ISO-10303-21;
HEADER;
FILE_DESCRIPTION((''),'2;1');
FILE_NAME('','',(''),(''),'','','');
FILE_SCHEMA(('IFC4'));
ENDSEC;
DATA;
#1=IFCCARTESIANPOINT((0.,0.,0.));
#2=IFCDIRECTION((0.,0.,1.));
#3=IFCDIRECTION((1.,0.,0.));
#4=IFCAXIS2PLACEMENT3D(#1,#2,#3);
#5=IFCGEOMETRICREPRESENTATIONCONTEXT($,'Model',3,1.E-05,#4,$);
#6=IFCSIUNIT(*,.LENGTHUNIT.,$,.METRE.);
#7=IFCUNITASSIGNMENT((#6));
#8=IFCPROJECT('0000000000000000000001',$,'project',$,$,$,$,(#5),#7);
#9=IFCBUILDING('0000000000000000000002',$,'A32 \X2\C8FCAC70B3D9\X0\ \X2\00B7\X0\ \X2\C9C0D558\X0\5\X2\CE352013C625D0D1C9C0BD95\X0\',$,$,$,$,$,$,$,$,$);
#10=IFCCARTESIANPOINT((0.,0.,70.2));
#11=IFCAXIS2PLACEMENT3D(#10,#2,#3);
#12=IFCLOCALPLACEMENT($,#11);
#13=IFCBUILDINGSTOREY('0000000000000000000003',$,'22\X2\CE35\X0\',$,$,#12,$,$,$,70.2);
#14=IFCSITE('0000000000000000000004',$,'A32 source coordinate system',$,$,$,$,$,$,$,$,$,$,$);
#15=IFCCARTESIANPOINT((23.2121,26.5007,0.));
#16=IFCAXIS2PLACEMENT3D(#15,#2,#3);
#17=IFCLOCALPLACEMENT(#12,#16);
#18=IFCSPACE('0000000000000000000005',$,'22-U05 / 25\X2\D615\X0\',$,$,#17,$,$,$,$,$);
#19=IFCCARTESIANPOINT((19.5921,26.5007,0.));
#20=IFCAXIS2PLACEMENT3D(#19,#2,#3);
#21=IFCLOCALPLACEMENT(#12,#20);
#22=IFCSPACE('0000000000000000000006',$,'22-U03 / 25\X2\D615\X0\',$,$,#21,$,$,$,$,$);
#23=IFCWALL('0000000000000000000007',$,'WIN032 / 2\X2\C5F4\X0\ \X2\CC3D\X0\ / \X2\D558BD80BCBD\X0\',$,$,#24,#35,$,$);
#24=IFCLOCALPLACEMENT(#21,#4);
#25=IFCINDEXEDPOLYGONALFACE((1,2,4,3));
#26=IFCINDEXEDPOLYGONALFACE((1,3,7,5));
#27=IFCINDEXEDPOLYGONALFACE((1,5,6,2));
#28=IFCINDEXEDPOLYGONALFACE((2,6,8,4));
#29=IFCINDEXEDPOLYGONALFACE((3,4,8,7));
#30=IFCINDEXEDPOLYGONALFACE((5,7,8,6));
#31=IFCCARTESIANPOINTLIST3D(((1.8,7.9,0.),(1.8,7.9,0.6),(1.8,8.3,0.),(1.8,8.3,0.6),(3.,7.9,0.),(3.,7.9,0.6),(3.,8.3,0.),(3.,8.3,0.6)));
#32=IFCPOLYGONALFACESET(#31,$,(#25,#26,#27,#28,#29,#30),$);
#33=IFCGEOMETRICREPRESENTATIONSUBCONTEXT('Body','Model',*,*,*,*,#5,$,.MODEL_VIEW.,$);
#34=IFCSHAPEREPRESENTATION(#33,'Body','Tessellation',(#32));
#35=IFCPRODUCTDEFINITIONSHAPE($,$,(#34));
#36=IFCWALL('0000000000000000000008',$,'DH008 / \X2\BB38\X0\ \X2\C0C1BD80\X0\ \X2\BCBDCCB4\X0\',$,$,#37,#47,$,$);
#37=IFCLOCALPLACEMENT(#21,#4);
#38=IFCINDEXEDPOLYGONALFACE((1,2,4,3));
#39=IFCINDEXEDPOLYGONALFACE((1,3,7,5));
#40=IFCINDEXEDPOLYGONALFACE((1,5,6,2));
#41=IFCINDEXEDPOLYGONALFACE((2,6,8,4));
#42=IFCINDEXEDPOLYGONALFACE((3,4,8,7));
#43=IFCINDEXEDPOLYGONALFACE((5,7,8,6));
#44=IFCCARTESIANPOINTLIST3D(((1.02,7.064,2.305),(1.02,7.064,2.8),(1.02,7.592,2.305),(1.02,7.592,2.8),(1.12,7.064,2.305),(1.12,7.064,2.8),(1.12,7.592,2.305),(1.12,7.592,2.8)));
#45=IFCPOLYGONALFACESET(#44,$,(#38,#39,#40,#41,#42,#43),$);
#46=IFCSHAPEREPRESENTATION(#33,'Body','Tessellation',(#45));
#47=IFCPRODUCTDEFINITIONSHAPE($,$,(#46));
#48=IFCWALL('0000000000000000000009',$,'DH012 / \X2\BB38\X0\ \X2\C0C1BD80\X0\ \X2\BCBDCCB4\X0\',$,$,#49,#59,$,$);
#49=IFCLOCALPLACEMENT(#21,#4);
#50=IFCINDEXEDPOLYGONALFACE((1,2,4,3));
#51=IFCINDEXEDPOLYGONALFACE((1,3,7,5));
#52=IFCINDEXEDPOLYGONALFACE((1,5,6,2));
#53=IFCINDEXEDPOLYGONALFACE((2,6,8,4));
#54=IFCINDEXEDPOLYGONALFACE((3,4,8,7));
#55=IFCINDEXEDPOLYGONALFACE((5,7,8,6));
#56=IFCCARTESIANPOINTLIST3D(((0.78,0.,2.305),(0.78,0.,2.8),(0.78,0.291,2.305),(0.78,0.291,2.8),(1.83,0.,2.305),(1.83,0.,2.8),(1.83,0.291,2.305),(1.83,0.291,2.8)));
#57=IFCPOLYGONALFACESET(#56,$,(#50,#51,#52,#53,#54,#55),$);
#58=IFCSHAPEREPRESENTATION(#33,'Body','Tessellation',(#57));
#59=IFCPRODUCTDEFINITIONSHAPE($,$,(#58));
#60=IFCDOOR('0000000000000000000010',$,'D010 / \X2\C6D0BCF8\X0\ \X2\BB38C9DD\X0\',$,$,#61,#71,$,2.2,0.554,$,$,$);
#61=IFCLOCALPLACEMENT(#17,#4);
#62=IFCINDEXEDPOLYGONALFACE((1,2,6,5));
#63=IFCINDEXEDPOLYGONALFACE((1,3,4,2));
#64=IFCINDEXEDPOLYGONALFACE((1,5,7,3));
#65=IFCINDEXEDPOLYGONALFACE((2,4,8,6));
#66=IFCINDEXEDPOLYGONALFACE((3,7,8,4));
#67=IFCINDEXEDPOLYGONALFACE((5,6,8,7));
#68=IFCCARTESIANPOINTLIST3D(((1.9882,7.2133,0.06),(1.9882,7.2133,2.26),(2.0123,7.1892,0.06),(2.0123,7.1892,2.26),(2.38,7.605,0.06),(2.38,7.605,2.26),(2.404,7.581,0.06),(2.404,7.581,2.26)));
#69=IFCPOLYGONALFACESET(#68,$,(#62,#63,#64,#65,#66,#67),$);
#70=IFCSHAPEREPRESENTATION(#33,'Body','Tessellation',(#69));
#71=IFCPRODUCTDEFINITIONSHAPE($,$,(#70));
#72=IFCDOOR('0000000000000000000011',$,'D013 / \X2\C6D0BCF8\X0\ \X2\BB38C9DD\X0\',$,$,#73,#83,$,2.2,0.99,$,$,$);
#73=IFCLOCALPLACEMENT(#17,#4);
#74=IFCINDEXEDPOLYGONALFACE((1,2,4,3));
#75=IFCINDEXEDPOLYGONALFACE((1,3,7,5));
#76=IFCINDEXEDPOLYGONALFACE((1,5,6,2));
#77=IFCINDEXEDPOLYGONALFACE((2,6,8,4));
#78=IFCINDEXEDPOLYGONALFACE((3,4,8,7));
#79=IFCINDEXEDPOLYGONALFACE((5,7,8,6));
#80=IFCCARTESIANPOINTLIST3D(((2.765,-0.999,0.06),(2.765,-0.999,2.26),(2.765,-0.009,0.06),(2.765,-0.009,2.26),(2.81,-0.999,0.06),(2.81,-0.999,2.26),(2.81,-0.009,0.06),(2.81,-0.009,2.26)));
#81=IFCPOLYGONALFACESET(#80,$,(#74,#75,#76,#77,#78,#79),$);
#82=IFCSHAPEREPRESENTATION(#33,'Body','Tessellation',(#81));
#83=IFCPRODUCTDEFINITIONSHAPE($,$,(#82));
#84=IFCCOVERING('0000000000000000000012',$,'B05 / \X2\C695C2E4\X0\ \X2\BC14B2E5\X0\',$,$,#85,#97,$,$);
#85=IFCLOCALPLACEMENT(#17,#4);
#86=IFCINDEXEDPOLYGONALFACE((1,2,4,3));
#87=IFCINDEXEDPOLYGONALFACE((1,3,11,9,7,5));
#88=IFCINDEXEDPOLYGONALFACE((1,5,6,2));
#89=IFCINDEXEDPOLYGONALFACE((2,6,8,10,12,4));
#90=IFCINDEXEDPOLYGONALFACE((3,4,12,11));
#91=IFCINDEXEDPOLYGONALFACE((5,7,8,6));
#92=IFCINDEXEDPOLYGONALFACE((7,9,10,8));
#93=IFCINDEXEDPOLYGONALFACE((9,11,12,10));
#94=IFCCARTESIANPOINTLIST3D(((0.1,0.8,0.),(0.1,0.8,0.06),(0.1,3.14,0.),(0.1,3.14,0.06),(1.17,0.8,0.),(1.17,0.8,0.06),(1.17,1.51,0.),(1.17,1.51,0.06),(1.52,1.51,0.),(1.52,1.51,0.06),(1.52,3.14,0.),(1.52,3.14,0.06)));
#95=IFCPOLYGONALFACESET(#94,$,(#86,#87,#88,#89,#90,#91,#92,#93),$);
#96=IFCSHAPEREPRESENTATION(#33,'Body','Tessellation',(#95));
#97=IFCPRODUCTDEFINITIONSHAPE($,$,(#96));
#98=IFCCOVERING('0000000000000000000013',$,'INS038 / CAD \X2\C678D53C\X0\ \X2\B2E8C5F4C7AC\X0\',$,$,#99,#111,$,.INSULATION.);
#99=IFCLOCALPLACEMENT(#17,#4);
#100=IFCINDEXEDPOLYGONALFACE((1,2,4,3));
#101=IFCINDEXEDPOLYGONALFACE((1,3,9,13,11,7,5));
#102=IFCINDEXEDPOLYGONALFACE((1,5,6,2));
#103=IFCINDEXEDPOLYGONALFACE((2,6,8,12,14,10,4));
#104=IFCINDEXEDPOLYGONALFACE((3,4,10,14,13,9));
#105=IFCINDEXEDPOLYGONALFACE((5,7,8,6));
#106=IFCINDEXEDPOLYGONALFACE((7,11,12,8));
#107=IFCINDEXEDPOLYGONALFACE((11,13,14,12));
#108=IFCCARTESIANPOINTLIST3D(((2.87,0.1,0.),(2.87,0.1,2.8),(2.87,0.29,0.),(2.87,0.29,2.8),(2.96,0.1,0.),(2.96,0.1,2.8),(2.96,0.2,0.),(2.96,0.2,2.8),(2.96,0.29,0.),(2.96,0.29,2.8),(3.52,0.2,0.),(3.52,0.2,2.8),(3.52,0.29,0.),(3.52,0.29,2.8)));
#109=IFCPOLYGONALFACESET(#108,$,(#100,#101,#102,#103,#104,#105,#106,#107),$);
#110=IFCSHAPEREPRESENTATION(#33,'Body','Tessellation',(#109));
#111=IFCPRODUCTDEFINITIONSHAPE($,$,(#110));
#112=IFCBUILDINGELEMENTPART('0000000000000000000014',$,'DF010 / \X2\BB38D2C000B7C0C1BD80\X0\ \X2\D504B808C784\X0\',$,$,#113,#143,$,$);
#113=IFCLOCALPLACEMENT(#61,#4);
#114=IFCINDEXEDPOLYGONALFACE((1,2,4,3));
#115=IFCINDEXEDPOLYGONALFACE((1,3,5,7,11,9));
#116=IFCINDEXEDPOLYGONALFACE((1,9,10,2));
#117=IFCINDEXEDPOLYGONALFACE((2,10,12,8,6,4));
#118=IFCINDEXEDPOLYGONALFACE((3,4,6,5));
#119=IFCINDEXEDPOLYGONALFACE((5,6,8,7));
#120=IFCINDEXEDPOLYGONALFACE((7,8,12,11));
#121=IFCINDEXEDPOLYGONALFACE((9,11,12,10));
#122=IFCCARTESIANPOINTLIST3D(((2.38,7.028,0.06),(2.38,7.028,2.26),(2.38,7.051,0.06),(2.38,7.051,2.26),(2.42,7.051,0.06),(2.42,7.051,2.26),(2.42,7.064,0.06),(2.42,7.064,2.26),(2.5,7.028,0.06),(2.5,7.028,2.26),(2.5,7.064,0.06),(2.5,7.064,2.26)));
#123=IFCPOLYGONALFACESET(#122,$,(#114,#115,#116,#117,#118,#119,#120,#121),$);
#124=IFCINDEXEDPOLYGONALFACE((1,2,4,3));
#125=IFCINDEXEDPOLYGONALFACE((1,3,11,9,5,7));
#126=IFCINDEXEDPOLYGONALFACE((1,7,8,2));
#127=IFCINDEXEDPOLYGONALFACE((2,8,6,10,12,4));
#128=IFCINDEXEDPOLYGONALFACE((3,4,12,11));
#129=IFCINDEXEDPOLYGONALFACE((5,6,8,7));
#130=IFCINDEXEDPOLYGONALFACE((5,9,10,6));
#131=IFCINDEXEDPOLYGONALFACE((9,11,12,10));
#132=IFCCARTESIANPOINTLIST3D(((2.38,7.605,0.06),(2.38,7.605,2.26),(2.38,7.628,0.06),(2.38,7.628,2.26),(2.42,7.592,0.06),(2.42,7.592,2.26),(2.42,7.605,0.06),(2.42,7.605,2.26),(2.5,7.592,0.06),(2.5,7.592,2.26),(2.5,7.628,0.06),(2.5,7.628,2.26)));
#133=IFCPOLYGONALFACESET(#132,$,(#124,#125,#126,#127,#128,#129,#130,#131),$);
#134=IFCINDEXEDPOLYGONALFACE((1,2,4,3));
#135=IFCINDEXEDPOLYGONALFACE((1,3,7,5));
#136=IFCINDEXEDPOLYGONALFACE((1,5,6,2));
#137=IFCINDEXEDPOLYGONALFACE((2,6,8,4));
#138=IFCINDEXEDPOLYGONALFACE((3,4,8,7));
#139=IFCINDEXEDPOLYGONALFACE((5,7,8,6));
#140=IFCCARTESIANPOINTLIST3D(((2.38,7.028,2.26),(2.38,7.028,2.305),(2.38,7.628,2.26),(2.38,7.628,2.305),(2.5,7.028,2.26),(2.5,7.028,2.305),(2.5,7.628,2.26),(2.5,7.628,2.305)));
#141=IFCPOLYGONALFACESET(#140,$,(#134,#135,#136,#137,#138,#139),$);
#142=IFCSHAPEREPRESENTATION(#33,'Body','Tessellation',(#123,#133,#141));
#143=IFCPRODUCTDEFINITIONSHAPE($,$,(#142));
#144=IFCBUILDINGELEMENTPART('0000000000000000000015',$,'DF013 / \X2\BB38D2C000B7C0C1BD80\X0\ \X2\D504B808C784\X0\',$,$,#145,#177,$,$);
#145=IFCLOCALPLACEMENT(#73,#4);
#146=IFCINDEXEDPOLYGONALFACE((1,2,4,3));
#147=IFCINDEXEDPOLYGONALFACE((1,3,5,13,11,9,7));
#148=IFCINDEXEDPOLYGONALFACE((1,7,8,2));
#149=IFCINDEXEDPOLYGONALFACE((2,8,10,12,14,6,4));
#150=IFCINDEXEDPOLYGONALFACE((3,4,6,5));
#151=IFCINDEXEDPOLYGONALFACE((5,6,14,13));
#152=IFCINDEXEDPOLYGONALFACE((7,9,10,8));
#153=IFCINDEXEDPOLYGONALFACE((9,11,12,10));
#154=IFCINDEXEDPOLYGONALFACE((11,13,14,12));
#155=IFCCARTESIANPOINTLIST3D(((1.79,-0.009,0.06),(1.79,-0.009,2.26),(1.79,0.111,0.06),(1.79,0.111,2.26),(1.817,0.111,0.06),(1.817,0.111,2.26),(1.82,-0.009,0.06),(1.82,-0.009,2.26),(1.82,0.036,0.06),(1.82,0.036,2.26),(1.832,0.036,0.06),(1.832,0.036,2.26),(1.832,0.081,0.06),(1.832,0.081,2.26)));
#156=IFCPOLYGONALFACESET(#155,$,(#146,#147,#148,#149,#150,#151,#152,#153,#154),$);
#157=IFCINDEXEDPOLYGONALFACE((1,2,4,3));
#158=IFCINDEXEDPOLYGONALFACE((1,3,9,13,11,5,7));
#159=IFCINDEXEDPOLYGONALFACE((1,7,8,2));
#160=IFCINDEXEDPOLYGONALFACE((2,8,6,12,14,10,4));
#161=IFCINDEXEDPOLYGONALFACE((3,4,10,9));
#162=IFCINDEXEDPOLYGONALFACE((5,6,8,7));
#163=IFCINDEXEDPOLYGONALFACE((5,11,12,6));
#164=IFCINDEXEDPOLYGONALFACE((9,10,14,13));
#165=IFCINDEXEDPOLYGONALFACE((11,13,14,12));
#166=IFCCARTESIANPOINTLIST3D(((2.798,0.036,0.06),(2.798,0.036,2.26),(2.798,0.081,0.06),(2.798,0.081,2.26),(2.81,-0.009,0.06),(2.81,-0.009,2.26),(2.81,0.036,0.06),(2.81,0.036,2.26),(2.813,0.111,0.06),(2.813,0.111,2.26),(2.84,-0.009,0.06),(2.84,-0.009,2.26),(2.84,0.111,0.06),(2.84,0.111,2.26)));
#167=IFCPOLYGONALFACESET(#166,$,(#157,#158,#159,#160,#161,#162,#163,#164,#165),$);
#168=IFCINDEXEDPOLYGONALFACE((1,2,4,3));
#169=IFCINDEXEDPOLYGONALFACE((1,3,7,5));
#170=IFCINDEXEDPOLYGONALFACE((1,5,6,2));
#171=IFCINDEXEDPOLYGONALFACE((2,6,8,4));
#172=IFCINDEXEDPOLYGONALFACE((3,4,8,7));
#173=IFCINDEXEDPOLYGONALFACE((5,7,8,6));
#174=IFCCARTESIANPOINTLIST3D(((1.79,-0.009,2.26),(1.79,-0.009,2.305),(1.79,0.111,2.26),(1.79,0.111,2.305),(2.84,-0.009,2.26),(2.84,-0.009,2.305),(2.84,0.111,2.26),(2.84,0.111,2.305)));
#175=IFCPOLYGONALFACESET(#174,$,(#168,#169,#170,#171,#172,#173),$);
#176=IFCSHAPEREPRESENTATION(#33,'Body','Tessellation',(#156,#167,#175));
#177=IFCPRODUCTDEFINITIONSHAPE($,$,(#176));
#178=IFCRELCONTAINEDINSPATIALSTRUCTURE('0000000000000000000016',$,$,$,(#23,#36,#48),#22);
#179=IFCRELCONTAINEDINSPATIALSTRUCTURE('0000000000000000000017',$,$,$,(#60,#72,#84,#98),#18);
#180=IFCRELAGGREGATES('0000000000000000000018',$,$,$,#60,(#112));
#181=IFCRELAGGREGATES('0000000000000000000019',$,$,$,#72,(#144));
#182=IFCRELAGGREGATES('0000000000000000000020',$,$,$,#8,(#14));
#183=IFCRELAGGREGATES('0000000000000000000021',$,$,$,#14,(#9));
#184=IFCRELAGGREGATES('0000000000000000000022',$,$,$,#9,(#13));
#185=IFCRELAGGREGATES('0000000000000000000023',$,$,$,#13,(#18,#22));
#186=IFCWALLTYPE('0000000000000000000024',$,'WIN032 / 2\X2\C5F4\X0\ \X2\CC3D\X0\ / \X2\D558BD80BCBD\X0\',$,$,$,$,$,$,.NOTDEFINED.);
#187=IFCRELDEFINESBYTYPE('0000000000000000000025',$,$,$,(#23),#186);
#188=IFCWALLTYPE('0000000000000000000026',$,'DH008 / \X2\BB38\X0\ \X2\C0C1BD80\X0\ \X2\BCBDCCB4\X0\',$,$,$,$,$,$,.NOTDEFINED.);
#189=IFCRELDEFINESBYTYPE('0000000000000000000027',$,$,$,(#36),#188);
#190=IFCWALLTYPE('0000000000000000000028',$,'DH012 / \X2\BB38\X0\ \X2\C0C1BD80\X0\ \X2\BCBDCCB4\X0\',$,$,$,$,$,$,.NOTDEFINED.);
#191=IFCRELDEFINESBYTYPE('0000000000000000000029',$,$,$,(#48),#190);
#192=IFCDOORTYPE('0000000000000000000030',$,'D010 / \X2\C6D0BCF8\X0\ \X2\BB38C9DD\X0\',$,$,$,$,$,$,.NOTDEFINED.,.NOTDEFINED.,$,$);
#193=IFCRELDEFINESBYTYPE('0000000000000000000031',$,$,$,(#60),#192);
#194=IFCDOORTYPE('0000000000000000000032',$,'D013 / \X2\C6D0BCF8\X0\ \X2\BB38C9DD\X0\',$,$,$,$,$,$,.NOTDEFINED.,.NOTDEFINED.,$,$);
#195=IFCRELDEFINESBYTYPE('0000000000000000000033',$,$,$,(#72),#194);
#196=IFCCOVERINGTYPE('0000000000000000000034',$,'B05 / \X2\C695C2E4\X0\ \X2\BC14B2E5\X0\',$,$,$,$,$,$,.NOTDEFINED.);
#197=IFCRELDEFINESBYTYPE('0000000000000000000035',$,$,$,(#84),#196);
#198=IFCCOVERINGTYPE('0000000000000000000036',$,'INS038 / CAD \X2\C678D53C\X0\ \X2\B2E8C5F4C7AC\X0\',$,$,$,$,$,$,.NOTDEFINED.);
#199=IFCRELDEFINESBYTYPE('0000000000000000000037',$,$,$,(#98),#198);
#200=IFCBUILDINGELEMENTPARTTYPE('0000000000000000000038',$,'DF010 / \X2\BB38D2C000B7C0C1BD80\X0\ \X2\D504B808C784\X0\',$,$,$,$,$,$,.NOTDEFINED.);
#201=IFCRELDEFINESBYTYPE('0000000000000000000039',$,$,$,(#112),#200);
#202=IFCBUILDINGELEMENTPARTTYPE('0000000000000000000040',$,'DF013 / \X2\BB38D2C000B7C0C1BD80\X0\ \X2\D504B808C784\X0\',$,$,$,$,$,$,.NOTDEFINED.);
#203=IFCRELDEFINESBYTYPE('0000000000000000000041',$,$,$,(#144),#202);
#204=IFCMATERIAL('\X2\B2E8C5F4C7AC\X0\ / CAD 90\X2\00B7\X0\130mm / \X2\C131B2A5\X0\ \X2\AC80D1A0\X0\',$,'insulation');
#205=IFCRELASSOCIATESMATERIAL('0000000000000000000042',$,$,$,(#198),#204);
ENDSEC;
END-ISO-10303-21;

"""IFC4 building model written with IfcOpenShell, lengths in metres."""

from ifc_helpers import new_model, si_unit, frame, origin, origin_with_axes, place, context, subcontext, project, spatial, polyline, outline, extrude, source, transform, mapped, material, type_object, type_shapes, element, aggregate, save


model = new_model("IFC4")

# Units and contexts
model_context = context("Model", 3, precision=1e-05, world=origin_with_axes())
body_context = subcontext(model_context, "Body", "Model", "MODEL_VIEW")
ifc_project = project(units=[si_unit("LENGTHUNIT", "METRE")], contexts=[model_context])

# Site, building, storey, space
storey_placement = place(None, frame((0.0, 0.0, 70.2), z_axis=(0.0, 0.0, 1.0), x_axis=(1.0, 0.0, 0.0)))
space_1_placement = place(storey_placement, frame((23.2121, 26.5007, 0.0), z_axis=(0.0, 0.0, 1.0), x_axis=(1.0, 0.0, 0.0)))
site = spatial("IfcSite", under=ifc_project, Name="A32 source coordinate system")
building = spatial("IfcBuilding", under=site, Name="A32 주거동 · 지하5층–옥탑지붕")
storey = spatial("IfcBuildingStorey", under=building, at=storey_placement, Name="22층", Elevation=70.2)
space_1 = spatial("IfcSpace", under=storey, at=space_1_placement, Name="22-U05 / 25형")

# Shared definitions
space_2_placement = place(storey_placement, frame((19.5921, 26.5007, 0.0), z_axis=(0.0, 0.0, 1.0), x_axis=(1.0, 0.0, 0.0)))
space_2 = spatial("IfcSpace", under=storey, at=space_2_placement, Name="22-U03 / 25형")

# Walls
wall_type_1 = type_object("IfcWallType", Name="WIN032 / 2열 창 / 하부벽", PredefinedType="NOTDEFINED")
shared_shape_1 = source(origin(), body_context, "Body", "SweptSolid", [
    extrude(outline(polyline([(3.0, 7.9), (1.8, 7.9), (1.8, 8.3), (3.0, 8.3), (3.0, 7.9)])), origin(), (0.0, 0.0, 1.0), 0.6),
])
type_shapes(wall_type_1, [shared_shape_1])
wall_1_placement = place(space_2_placement, origin_with_axes())
element("IfcWall", 1, at=wall_1_placement, inside=space_2, type_object=wall_type_1, Name="WIN032 / 2열 창 / 하부벽", context=body_context, shape_type="MappedRepresentation", body=[
    mapped(shared_shape_1, transform((0.0, 0.0, 0.0), scale=1.0)),
])
wall_type_2 = type_object("IfcWallType", Name="DH008 / 문 상부 벽체", PredefinedType="NOTDEFINED")
shared_shape_2 = source(origin(), body_context, "Body", "SweptSolid", [
    extrude(outline(polyline([(1.12, 7.064), (1.02, 7.064), (1.02, 7.592), (1.12, 7.592), (1.12, 7.064)])), frame((0.0, 0.0, 2.305)), (0.0, 0.0, 1.0), 0.495),
])
type_shapes(wall_type_2, [shared_shape_2])
wall_2_placement = place(space_2_placement, origin_with_axes())
element("IfcWall", 2, at=wall_2_placement, inside=space_2, type_object=wall_type_2, Name="DH008 / 문 상부 벽체", context=body_context, shape_type="MappedRepresentation", body=[
    mapped(shared_shape_2, transform((0.0, 0.0, 0.0), scale=1.0)),
])
wall_type_3 = type_object("IfcWallType", Name="DH012 / 문 상부 벽체", PredefinedType="NOTDEFINED")
shared_shape_3 = source(origin(), body_context, "Body", "SweptSolid", [
    extrude(outline(polyline([(0.78, 0.0), (0.78, 0.291), (1.83, 0.291), (1.83, 0.0), (0.78, 0.0)])), frame((0.0, 0.0, 2.305)), (0.0, 0.0, 1.0), 0.495),
])
type_shapes(wall_type_3, [shared_shape_3])
wall_3_placement = place(space_2_placement, origin_with_axes())
element("IfcWall", 3, at=wall_3_placement, inside=space_2, type_object=wall_type_3, Name="DH012 / 문 상부 벽체", context=body_context, shape_type="MappedRepresentation", body=[
    mapped(shared_shape_3, transform((0.0, 0.0, 0.0), scale=1.0)),
])

# Doors
door_type_1 = type_object("IfcDoorType", Name="D010 / 원본 문짝", OperationType="NOTDEFINED", PredefinedType="NOTDEFINED")
shared_shape_4 = source(origin(), body_context, "Body", "SweptSolid", [
    extrude(outline(polyline([(2.0123, 7.1892), (1.9882, 7.2133), (2.38, 7.605), (2.404, 7.581), (2.0123, 7.1892)])), frame((0.0, 0.0, 0.06)), (0.0, 0.0, 1.0), 2.2),
])
type_shapes(door_type_1, [shared_shape_4])
door_1_placement = place(space_1_placement, origin_with_axes())
door_1 = element("IfcDoor", 4, at=door_1_placement, inside=space_1, type_object=door_type_1, Name="D010 / 원본 문짝", OverallHeight=2.2, OverallWidth=0.554, context=body_context, shape_type="MappedRepresentation", body=[
    mapped(shared_shape_4, transform((0.0, 0.0, 0.0), scale=1.0)),
])
door_type_2 = type_object("IfcDoorType", Name="D013 / 원본 문짝", OperationType="NOTDEFINED", PredefinedType="NOTDEFINED")
shared_shape_5 = source(origin(), body_context, "Body", "SweptSolid", [
    extrude(outline(polyline([(2.81, -0.009), (2.81, -0.999), (2.765, -0.999), (2.765, -0.009), (2.81, -0.009)])), frame((0.0, 0.0, 0.06)), (0.0, 0.0, 1.0), 2.2),
])
type_shapes(door_type_2, [shared_shape_5])
door_2_placement = place(space_1_placement, origin_with_axes())
door_2 = element("IfcDoor", 5, at=door_2_placement, inside=space_1, type_object=door_type_2, Name="D013 / 원본 문짝", OverallHeight=2.2, OverallWidth=0.99, context=body_context, shape_type="MappedRepresentation", body=[
    mapped(shared_shape_5, transform((0.0, 0.0, 0.0), scale=1.0)),
])

# Coverings
covering_type_1 = type_object("IfcCoveringType", Name="B05 / 욕실 바닥", PredefinedType="NOTDEFINED")
shared_shape_6 = source(origin(), body_context, "Body", "SweptSolid", [
    extrude(outline(polyline([(0.1, 3.14), (1.52, 3.14), (1.52, 1.51), (1.17, 1.51), (1.17, 0.8), (0.1, 0.8), (0.1, 3.14)])), origin(), (0.0, 0.0, 1.0), 0.06),
])
type_shapes(covering_type_1, [shared_shape_6])
covering_1_placement = place(space_1_placement, origin_with_axes())
element("IfcCovering", 6, at=covering_1_placement, inside=space_1, type_object=covering_type_1, Name="B05 / 욕실 바닥", context=body_context, shape_type="MappedRepresentation", body=[
    mapped(shared_shape_6, transform((0.0, 0.0, 0.0), scale=1.0)),
])
ifc_material = material(Name="단열재 / CAD 90·130mm / 성능 검토", Category="insulation")
covering_type_2 = type_object("IfcCoveringType", Name="INS038 / CAD 외피 단열재", PredefinedType="NOTDEFINED", material=ifc_material)
shared_shape_7 = source(origin(), body_context, "Body", "SweptSolid", [
    extrude(outline(polyline([(2.96, 0.2), (2.96, 0.1), (2.87, 0.1), (2.87, 0.29), (2.96, 0.29), (3.52, 0.29), (3.52, 0.2), (2.96, 0.2)])), origin(), (0.0, 0.0, 1.0), 2.8),
])
type_shapes(covering_type_2, [shared_shape_7])
covering_2_placement = place(space_1_placement, origin_with_axes())
element("IfcCovering", 7, at=covering_2_placement, inside=space_1, type_object=covering_type_2, Name="INS038 / CAD 외피 단열재", PredefinedType="INSULATION", context=body_context, shape_type="MappedRepresentation", body=[
    mapped(shared_shape_7, transform((0.0, 0.0, 0.0), scale=1.0)),
])

# Building element parts
building_element_part_type_1 = type_object("IfcBuildingElementPartType", Name="DF010 / 문틀·상부 프레임", PredefinedType="NOTDEFINED")
shared_shape_8 = source(origin(), body_context, "Body", "SweptSolid", [
    extrude(outline(polyline([(2.38, 7.028), (2.38, 7.051), (2.42, 7.051), (2.42, 7.064), (2.5, 7.064), (2.5, 7.028), (2.38, 7.028)])), frame((0.0, 0.0, 0.06)), (0.0, 0.0, 1.0), 2.2),
    extrude(outline(polyline([(2.5, 7.592), (2.42, 7.592), (2.42, 7.605), (2.38, 7.605), (2.38, 7.628), (2.5, 7.628), (2.5, 7.592)])), frame((0.0, 0.0, 0.06)), (0.0, 0.0, 1.0), 2.2),
    extrude(outline(polyline([(2.38, 7.028), (2.38, 7.628), (2.5, 7.628), (2.5, 7.028), (2.38, 7.028)])), frame((0.0, 0.0, 2.26)), (0.0, 0.0, 1.0), 0.045),
])
type_shapes(building_element_part_type_1, [shared_shape_8])
building_element_part_1_placement = place(door_1_placement, origin_with_axes())
building_element_part_1 = element("IfcBuildingElementPart", 8, at=building_element_part_1_placement, type_object=building_element_part_type_1, Name="DF010 / 문틀·상부 프레임", context=body_context, shape_type="MappedRepresentation", body=[
    mapped(shared_shape_8, transform((0.0, 0.0, 0.0), scale=1.0)),
])
aggregate(door_1, [building_element_part_1])
building_element_part_type_2 = type_object("IfcBuildingElementPartType", Name="DF013 / 문틀·상부 프레임", PredefinedType="NOTDEFINED")
shared_shape_9 = source(origin(), body_context, "Body", "SweptSolid", [
    extrude(outline(polyline([(1.79, 0.111), (1.817, 0.111), (1.832, 0.081), (1.832, 0.036), (1.82, 0.036), (1.82, -0.009), (1.79, -0.009), (1.79, 0.111)])), frame((0.0, 0.0, 0.06)), (0.0, 0.0, 1.0), 2.2),
    extrude(outline(polyline([(2.81, -0.009), (2.81, 0.036), (2.798, 0.036), (2.798, 0.081), (2.813, 0.111), (2.84, 0.111), (2.84, -0.009), (2.81, -0.009)])), frame((0.0, 0.0, 0.06)), (0.0, 0.0, 1.0), 2.2),
    extrude(outline(polyline([(1.79, -0.009), (1.79, 0.111), (2.84, 0.111), (2.84, -0.009), (1.79, -0.009)])), frame((0.0, 0.0, 2.26)), (0.0, 0.0, 1.0), 0.045),
])
type_shapes(building_element_part_type_2, [shared_shape_9])
building_element_part_2_placement = place(door_2_placement, origin_with_axes())
building_element_part_2 = element("IfcBuildingElementPart", 9, at=building_element_part_2_placement, type_object=building_element_part_type_2, Name="DF013 / 문틀·상부 프레임", context=body_context, shape_type="MappedRepresentation", body=[
    mapped(shared_shape_9, transform((0.0, 0.0, 0.0), scale=1.0)),
])
aggregate(door_2, [building_element_part_2])

save(model, "model.ifc")
